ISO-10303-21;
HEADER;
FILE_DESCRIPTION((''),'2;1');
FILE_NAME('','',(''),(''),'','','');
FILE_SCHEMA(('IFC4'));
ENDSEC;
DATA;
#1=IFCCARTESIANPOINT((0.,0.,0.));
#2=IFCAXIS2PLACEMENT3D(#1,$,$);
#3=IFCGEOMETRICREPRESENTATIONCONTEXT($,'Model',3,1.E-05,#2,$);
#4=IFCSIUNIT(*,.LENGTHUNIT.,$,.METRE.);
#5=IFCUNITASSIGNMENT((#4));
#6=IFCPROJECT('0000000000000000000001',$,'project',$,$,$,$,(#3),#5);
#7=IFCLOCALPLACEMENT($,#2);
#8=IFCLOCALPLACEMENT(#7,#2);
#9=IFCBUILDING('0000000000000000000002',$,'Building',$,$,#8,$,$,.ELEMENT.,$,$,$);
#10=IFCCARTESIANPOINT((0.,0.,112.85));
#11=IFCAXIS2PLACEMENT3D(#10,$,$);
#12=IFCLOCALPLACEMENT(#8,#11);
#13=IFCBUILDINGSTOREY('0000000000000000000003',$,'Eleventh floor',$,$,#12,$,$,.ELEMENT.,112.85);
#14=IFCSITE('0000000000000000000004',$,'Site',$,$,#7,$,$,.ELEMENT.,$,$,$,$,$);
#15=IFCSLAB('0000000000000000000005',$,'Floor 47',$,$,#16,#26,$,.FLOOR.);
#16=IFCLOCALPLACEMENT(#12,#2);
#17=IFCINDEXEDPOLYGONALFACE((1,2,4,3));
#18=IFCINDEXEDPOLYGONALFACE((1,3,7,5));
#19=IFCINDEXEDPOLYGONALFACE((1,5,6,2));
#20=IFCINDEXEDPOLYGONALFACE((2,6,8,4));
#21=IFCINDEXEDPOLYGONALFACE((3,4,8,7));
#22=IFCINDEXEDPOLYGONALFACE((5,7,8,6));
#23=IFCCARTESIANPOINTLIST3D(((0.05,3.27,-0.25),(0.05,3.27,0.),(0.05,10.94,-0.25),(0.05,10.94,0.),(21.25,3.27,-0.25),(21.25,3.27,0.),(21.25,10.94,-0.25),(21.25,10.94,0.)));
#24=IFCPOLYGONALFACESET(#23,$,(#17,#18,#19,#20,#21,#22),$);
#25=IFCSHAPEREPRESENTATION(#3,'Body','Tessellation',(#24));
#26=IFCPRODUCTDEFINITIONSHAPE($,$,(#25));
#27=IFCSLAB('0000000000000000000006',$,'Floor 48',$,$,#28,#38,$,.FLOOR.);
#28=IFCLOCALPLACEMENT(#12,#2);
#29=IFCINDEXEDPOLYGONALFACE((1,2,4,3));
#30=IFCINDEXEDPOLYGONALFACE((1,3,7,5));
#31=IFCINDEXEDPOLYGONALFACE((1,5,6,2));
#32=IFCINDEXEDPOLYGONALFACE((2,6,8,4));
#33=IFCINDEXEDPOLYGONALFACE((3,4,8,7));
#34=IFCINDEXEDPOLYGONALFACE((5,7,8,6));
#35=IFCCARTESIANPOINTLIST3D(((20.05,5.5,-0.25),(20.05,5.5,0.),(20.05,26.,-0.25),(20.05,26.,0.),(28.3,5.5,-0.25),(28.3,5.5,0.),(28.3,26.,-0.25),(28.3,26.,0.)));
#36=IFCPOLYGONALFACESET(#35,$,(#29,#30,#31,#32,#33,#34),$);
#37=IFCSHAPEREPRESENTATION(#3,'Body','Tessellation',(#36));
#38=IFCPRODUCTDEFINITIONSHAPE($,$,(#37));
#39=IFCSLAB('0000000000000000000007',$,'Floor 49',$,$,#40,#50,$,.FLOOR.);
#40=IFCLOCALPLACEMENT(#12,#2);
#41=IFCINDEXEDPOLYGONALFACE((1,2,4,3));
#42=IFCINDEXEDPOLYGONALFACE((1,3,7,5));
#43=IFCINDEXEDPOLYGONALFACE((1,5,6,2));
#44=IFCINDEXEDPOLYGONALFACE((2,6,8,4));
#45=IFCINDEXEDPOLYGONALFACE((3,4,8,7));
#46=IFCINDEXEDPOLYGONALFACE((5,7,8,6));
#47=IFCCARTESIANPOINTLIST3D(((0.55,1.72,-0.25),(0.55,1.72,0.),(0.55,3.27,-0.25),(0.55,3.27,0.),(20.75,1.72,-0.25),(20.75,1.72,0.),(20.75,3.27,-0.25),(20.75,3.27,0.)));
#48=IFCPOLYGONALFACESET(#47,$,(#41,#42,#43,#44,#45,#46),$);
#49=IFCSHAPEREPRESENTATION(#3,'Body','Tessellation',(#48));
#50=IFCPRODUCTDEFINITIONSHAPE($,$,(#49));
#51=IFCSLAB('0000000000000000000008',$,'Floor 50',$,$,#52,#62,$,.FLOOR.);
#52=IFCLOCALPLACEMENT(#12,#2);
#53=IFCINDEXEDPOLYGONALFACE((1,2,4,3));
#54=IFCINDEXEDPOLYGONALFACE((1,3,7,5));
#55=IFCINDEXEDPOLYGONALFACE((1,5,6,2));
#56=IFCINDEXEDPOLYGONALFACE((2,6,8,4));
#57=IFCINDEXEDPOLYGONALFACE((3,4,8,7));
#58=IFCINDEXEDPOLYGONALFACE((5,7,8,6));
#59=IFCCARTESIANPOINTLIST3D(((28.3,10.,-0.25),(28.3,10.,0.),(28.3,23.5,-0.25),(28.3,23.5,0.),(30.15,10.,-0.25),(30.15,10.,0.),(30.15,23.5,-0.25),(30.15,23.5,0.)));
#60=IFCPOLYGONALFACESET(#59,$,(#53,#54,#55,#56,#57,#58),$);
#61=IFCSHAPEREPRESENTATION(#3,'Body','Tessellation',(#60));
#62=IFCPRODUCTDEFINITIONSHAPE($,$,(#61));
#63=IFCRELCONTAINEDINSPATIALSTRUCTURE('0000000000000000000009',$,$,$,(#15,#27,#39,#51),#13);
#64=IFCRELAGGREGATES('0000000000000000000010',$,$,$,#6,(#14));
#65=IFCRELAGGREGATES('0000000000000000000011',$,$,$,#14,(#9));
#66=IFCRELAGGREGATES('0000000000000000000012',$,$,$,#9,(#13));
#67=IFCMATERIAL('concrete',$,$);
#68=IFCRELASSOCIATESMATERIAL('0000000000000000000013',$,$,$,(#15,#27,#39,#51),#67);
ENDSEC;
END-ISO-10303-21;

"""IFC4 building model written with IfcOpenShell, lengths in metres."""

from ifc_helpers import new_model, si_unit, frame, origin, place, context, project, spatial, polyline, outline, extrude, material, element, save


model = new_model("IFC4")

# Units and contexts
model_context = context("Model", 3, precision=1e-05, world=origin())
ifc_project = project(units=[si_unit("LENGTHUNIT", "METRE")], contexts=[model_context])

# Site, building, storey
site_placement = place(None, origin())
site = spatial("IfcSite", under=ifc_project, at=site_placement, Name="Site", CompositionType="ELEMENT")
building_placement = place(site_placement, origin())
building = spatial("IfcBuilding", under=site, at=building_placement, Name="Building", CompositionType="ELEMENT")
storey_placement = place(building_placement, frame((0.0, 0.0, 112.85)))
storey = spatial("IfcBuildingStorey", under=building, at=storey_placement, Name="Eleventh floor", CompositionType="ELEMENT", Elevation=112.85)

# Slabs
ifc_material = material(Name="concrete")
slab_1_placement = place(storey_placement, frame((0.0, 0.0, -0.25), z_axis=(0.0, 0.0, 1.0), x_axis=(1.0, 0.0, 0.0)))
element("IfcSlab", 1, at=slab_1_placement, inside=storey, material=ifc_material, Name="Floor 47", PredefinedType="FLOOR", context=model_context, shape_type="SweptSolid", body=[
    extrude(outline(polyline([(0.05, 3.27), (21.25, 3.27), (21.25, 10.94), (0.05, 10.94), (0.05, 3.27)])), origin(), (0.0, 0.0, 1.0), 0.25),
])
slab_2_placement = place(storey_placement, frame((0.0, 0.0, -0.25), z_axis=(0.0, 0.0, 1.0), x_axis=(1.0, 0.0, 0.0)))
element("IfcSlab", 2, at=slab_2_placement, inside=storey, material=ifc_material, Name="Floor 48", PredefinedType="FLOOR", context=model_context, shape_type="SweptSolid", body=[
    extrude(outline(polyline([(20.05, 5.5), (28.3, 5.5), (28.3, 26.0), (20.05, 26.0), (20.05, 5.5)])), origin(), (0.0, 0.0, 1.0), 0.25),
])
slab_3_placement = place(storey_placement, frame((0.0, 0.0, -0.25), z_axis=(0.0, 0.0, 1.0), x_axis=(1.0, 0.0, 0.0)))
element("IfcSlab", 3, at=slab_3_placement, inside=storey, material=ifc_material, Name="Floor 49", PredefinedType="FLOOR", context=model_context, shape_type="SweptSolid", body=[
    extrude(outline(polyline([(0.55, 1.72), (20.75, 1.72), (20.75, 3.27), (0.55, 3.27), (0.55, 1.72)])), origin(), (0.0, 0.0, 1.0), 0.25),
])
slab_4_placement = place(storey_placement, frame((0.0, 0.0, -0.25), z_axis=(0.0, 0.0, 1.0), x_axis=(1.0, 0.0, 0.0)))
element("IfcSlab", 4, at=slab_4_placement, inside=storey, material=ifc_material, Name="Floor 50", PredefinedType="FLOOR", context=model_context, shape_type="SweptSolid", body=[
    extrude(outline(polyline([(28.3, 10.0), (30.15, 10.0), (30.15, 23.5), (28.3, 23.5), (28.3, 10.0)])), origin(), (0.0, 0.0, 1.0), 0.25),
])

save(model, "model.ifc")
